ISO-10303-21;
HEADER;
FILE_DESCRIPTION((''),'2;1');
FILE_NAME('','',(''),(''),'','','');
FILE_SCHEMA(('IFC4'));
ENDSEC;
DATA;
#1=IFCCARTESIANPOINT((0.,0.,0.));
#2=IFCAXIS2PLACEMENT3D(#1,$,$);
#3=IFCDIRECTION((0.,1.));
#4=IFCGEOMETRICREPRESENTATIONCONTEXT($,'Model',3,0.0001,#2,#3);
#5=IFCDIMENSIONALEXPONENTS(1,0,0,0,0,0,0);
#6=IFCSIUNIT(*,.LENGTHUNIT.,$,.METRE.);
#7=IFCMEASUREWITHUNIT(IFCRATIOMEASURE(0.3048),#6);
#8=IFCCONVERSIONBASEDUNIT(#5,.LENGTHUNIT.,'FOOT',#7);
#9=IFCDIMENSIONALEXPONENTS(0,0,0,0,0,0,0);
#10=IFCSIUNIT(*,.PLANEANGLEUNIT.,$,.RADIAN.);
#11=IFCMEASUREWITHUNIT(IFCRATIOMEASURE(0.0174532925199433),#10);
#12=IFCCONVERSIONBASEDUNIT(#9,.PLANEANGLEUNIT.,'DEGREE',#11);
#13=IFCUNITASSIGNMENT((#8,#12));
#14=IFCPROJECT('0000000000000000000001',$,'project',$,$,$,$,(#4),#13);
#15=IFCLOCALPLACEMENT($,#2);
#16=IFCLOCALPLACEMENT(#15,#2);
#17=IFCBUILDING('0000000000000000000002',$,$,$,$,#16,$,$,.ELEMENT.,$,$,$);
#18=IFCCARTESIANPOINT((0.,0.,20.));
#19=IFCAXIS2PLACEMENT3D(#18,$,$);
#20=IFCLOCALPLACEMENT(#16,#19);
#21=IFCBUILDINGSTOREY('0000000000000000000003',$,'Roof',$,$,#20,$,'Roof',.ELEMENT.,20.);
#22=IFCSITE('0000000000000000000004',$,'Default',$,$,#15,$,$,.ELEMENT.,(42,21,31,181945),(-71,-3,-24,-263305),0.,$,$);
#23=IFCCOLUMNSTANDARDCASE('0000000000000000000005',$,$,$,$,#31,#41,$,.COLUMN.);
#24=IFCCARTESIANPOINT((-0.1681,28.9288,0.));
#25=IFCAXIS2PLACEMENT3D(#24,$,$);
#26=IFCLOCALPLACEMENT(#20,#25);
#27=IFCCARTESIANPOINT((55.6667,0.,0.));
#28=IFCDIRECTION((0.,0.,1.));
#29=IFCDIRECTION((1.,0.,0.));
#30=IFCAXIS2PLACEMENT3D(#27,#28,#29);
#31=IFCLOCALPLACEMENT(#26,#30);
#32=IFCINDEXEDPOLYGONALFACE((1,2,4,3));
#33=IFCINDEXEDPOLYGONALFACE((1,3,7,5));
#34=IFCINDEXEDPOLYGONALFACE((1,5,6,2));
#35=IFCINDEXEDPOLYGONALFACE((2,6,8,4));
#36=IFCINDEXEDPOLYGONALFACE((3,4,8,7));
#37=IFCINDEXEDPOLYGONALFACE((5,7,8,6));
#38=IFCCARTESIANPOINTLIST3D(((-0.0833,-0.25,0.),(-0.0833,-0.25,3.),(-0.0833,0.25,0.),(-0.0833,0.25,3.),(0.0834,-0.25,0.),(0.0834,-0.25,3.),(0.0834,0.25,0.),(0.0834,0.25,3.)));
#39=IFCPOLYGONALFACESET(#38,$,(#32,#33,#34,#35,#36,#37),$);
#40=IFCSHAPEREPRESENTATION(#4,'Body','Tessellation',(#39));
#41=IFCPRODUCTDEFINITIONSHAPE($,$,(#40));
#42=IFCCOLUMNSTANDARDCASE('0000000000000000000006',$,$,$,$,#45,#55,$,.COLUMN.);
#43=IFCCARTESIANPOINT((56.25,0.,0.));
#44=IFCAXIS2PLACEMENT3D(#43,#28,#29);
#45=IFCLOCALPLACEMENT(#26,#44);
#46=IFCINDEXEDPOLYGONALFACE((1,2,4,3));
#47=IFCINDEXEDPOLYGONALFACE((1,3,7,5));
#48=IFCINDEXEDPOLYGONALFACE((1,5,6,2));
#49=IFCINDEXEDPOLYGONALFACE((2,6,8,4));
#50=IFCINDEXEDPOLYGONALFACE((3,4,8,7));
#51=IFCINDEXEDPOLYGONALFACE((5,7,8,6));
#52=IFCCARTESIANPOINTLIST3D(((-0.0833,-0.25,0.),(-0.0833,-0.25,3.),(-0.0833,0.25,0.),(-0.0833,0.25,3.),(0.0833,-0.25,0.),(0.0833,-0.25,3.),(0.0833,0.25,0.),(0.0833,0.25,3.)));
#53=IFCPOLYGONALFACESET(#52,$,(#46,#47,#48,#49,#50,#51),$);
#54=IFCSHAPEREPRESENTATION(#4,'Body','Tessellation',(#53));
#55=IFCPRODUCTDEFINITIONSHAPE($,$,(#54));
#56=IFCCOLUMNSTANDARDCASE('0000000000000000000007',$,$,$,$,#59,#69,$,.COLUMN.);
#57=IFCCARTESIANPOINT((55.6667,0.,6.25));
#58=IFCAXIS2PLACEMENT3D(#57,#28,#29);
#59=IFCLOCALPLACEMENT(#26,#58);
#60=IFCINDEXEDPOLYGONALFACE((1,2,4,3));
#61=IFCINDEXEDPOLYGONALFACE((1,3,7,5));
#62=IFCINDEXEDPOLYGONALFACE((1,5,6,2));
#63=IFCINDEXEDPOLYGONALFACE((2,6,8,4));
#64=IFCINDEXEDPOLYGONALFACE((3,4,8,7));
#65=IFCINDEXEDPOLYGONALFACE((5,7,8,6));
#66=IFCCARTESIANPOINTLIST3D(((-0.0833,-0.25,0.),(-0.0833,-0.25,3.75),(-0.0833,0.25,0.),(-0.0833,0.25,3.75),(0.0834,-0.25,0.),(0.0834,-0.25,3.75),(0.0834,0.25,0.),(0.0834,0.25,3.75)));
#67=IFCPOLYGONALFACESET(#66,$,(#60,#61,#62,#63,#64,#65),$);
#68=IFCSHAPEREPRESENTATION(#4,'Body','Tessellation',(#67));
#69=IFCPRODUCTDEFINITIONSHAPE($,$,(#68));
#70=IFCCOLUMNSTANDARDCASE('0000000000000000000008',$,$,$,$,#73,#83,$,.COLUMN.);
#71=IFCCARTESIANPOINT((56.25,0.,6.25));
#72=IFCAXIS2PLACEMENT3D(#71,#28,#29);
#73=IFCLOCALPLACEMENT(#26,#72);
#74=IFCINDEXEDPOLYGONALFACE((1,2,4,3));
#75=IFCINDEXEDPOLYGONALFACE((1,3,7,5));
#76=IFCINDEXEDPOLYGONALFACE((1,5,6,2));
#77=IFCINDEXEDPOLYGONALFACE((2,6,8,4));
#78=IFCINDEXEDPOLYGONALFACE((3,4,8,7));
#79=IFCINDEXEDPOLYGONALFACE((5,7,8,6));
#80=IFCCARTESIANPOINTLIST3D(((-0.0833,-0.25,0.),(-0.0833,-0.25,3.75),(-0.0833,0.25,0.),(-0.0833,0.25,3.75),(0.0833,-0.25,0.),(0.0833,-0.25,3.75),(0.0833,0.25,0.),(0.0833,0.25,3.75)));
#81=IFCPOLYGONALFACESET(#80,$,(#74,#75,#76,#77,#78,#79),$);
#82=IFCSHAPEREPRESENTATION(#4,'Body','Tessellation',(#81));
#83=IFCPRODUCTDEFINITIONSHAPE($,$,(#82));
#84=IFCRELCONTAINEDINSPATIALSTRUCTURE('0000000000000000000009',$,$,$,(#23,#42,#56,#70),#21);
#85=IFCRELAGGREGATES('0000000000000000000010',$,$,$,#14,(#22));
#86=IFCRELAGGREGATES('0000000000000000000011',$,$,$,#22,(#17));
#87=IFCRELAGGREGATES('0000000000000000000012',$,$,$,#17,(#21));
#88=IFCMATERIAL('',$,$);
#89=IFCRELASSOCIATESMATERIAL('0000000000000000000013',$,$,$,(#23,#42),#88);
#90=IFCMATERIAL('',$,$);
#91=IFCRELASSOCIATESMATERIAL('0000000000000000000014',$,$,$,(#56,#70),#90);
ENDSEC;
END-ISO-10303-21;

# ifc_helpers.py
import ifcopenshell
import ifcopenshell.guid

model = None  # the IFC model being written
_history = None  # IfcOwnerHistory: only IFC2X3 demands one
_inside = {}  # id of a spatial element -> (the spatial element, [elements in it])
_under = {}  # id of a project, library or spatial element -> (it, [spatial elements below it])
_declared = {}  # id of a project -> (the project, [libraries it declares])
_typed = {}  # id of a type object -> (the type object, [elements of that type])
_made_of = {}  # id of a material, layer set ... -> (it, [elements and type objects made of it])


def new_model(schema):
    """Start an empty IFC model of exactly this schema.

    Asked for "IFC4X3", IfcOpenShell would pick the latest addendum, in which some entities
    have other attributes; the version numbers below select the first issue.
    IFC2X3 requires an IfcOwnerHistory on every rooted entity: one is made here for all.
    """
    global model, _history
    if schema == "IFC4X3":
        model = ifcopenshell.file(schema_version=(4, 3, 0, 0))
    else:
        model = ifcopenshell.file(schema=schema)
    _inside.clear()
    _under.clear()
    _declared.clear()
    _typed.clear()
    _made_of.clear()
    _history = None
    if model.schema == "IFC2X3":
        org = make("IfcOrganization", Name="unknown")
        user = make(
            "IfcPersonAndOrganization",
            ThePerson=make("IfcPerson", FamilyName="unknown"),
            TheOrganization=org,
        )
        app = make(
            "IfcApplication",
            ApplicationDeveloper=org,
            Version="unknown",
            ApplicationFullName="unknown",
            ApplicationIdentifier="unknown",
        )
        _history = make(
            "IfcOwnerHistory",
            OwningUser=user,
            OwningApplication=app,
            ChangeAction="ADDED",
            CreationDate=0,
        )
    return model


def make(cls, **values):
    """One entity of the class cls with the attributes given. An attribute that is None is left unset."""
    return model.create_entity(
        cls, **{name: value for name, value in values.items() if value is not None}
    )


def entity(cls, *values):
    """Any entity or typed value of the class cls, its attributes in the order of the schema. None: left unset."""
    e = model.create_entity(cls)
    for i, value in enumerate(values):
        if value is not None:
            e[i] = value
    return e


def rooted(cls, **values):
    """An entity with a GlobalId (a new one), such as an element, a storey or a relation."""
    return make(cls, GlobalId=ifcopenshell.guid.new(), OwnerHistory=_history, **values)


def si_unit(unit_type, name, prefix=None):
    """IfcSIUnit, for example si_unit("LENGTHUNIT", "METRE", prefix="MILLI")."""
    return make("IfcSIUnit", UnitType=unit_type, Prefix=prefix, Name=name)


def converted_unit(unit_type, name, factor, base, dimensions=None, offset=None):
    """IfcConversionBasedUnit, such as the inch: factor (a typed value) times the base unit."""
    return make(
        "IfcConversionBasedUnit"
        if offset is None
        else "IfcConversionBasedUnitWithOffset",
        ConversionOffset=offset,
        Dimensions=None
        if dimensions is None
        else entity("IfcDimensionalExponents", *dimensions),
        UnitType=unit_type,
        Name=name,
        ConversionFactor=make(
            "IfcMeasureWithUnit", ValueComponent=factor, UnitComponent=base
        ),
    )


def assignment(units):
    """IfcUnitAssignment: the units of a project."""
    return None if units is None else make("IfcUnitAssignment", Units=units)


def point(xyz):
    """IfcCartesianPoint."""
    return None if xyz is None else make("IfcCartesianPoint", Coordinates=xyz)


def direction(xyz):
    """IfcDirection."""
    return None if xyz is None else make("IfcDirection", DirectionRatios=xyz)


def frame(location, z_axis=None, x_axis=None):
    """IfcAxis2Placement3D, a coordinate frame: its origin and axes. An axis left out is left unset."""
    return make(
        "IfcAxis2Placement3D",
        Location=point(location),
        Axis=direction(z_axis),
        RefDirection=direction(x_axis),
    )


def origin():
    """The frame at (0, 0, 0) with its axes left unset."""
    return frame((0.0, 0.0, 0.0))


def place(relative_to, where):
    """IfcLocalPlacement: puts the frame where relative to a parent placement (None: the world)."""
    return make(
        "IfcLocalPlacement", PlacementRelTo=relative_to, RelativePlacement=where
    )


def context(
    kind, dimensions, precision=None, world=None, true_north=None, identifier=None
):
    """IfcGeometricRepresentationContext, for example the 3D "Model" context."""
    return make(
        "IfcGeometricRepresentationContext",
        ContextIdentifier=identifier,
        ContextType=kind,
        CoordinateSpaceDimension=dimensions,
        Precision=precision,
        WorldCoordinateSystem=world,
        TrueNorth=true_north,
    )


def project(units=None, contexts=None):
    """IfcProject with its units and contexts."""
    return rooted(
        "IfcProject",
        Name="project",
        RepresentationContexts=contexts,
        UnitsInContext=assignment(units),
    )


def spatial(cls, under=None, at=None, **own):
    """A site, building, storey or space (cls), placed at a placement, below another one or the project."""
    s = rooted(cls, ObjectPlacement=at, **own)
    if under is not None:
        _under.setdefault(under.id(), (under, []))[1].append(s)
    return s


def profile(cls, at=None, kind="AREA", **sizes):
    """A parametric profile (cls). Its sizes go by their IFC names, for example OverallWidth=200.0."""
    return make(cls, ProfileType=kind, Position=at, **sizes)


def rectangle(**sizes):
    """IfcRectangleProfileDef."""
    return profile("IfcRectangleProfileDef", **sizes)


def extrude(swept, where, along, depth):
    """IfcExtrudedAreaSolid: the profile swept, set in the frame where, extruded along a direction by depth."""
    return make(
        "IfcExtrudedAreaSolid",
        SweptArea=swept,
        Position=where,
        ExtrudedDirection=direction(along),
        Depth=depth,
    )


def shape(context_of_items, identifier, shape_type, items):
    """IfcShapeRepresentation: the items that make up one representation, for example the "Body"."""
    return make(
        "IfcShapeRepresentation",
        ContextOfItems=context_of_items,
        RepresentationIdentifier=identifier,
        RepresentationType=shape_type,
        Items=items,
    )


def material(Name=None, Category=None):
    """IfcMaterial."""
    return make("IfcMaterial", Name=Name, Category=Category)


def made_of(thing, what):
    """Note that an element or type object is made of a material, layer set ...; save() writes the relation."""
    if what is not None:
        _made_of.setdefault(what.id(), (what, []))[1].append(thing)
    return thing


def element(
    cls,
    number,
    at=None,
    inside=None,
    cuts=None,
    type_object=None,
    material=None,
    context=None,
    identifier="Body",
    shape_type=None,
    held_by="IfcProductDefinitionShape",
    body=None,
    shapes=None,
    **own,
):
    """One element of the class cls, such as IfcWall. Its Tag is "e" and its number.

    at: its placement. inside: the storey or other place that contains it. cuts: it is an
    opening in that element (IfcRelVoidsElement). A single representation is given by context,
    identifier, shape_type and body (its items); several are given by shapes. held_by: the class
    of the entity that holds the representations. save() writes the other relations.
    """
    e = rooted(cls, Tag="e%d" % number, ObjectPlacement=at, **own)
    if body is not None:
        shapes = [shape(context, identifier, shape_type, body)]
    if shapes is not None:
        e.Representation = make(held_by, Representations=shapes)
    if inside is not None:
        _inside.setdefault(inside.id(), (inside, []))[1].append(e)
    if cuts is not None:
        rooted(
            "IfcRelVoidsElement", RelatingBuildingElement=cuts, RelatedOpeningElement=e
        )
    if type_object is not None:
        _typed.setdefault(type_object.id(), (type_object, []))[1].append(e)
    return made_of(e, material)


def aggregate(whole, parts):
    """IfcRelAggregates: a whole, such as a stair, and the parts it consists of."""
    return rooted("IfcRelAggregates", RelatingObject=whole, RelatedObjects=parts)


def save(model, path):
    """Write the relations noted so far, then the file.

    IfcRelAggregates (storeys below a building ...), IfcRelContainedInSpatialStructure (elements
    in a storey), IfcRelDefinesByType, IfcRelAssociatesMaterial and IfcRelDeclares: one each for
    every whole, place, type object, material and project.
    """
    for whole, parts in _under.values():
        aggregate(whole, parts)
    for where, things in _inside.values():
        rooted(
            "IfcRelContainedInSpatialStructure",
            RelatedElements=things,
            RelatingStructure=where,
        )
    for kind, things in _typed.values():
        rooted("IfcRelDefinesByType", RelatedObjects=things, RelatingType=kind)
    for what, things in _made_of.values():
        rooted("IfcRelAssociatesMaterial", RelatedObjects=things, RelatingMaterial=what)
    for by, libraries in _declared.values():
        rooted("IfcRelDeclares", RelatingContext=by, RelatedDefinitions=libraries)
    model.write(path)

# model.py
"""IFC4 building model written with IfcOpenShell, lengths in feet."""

from ifc_helpers import new_model, entity, si_unit, converted_unit, direction, frame, origin, place, context, project, spatial, rectangle, extrude, material, element, save


model = new_model("IFC4")

# Units and contexts
model_context = context("Model", 3, precision=0.0001, world=origin(), true_north=direction((0.0, 1.0)))
ifc_project = project(units=[converted_unit("LENGTHUNIT", "FOOT", entity("IfcRatioMeasure", 0.3048), si_unit("LENGTHUNIT", "METRE"), dimensions=[1, 0, 0, 0, 0, 0, 0]), converted_unit("PLANEANGLEUNIT", "DEGREE", entity("IfcRatioMeasure", 0.0174532925199433), si_unit("PLANEANGLEUNIT", "RADIAN"), dimensions=[0, 0, 0, 0, 0, 0, 0])], contexts=[model_context])

# Site, building, storey
site_placement = place(None, origin())
site = spatial("IfcSite", under=ifc_project, at=site_placement, Name="Default", CompositionType="ELEMENT", RefLatitude=(42, 21, 31, 181945), RefLongitude=(-71, -3, -24, -263305), RefElevation=0.0)
building_placement = place(site_placement, origin())
building = spatial("IfcBuilding", under=site, at=building_placement, CompositionType="ELEMENT")
storey_placement = place(building_placement, frame((0.0, 0.0, 20.0)))
storey = spatial("IfcBuildingStorey", under=building, at=storey_placement, Name="Roof", LongName="Roof", CompositionType="ELEMENT", Elevation=20.0)

# Columns
ifc_material_1 = material(Name="")
placement = place(storey_placement, frame((-0.1681, 28.9288, 0.0)))
for number, where, z_axis, x_axis in (
    (1, (55.6667, 0.0, 0.0), (0.0, 0.0, 1.0), (1.0, 0.0, 0.0)),
    (2, (56.25, 0.0, 0.0), (0.0, 0.0, 1.0), (1.0, 0.0, 0.0)),
):
    element("IfcColumnStandardCase", number, at=place(placement, frame(where, z_axis=z_axis, x_axis=x_axis)), inside=storey, material=ifc_material_1, PredefinedType="COLUMN", context=model_context, shape_type="SweptSolid", body=[
        extrude(rectangle(XDim=0.1667, YDim=0.5), origin(), (0.0, 0.0, 1.0), 3.0),
    ])
ifc_material_2 = material(Name="")
for number, where, z_axis, x_axis in (
    (3, (55.6667, 0.0, 6.25), (0.0, 0.0, 1.0), (1.0, 0.0, 0.0)),
    (4, (56.25, 0.0, 6.25), (0.0, 0.0, 1.0), (1.0, 0.0, 0.0)),
):
    element("IfcColumnStandardCase", number, at=place(placement, frame(where, z_axis=z_axis, x_axis=x_axis)), inside=storey, material=ifc_material_2, PredefinedType="COLUMN", context=model_context, shape_type="SweptSolid", body=[
        extrude(rectangle(XDim=0.1667, YDim=0.5), origin(), (0.0, 0.0, 1.0), 3.75),
    ])

save(model, "model.ifc")
